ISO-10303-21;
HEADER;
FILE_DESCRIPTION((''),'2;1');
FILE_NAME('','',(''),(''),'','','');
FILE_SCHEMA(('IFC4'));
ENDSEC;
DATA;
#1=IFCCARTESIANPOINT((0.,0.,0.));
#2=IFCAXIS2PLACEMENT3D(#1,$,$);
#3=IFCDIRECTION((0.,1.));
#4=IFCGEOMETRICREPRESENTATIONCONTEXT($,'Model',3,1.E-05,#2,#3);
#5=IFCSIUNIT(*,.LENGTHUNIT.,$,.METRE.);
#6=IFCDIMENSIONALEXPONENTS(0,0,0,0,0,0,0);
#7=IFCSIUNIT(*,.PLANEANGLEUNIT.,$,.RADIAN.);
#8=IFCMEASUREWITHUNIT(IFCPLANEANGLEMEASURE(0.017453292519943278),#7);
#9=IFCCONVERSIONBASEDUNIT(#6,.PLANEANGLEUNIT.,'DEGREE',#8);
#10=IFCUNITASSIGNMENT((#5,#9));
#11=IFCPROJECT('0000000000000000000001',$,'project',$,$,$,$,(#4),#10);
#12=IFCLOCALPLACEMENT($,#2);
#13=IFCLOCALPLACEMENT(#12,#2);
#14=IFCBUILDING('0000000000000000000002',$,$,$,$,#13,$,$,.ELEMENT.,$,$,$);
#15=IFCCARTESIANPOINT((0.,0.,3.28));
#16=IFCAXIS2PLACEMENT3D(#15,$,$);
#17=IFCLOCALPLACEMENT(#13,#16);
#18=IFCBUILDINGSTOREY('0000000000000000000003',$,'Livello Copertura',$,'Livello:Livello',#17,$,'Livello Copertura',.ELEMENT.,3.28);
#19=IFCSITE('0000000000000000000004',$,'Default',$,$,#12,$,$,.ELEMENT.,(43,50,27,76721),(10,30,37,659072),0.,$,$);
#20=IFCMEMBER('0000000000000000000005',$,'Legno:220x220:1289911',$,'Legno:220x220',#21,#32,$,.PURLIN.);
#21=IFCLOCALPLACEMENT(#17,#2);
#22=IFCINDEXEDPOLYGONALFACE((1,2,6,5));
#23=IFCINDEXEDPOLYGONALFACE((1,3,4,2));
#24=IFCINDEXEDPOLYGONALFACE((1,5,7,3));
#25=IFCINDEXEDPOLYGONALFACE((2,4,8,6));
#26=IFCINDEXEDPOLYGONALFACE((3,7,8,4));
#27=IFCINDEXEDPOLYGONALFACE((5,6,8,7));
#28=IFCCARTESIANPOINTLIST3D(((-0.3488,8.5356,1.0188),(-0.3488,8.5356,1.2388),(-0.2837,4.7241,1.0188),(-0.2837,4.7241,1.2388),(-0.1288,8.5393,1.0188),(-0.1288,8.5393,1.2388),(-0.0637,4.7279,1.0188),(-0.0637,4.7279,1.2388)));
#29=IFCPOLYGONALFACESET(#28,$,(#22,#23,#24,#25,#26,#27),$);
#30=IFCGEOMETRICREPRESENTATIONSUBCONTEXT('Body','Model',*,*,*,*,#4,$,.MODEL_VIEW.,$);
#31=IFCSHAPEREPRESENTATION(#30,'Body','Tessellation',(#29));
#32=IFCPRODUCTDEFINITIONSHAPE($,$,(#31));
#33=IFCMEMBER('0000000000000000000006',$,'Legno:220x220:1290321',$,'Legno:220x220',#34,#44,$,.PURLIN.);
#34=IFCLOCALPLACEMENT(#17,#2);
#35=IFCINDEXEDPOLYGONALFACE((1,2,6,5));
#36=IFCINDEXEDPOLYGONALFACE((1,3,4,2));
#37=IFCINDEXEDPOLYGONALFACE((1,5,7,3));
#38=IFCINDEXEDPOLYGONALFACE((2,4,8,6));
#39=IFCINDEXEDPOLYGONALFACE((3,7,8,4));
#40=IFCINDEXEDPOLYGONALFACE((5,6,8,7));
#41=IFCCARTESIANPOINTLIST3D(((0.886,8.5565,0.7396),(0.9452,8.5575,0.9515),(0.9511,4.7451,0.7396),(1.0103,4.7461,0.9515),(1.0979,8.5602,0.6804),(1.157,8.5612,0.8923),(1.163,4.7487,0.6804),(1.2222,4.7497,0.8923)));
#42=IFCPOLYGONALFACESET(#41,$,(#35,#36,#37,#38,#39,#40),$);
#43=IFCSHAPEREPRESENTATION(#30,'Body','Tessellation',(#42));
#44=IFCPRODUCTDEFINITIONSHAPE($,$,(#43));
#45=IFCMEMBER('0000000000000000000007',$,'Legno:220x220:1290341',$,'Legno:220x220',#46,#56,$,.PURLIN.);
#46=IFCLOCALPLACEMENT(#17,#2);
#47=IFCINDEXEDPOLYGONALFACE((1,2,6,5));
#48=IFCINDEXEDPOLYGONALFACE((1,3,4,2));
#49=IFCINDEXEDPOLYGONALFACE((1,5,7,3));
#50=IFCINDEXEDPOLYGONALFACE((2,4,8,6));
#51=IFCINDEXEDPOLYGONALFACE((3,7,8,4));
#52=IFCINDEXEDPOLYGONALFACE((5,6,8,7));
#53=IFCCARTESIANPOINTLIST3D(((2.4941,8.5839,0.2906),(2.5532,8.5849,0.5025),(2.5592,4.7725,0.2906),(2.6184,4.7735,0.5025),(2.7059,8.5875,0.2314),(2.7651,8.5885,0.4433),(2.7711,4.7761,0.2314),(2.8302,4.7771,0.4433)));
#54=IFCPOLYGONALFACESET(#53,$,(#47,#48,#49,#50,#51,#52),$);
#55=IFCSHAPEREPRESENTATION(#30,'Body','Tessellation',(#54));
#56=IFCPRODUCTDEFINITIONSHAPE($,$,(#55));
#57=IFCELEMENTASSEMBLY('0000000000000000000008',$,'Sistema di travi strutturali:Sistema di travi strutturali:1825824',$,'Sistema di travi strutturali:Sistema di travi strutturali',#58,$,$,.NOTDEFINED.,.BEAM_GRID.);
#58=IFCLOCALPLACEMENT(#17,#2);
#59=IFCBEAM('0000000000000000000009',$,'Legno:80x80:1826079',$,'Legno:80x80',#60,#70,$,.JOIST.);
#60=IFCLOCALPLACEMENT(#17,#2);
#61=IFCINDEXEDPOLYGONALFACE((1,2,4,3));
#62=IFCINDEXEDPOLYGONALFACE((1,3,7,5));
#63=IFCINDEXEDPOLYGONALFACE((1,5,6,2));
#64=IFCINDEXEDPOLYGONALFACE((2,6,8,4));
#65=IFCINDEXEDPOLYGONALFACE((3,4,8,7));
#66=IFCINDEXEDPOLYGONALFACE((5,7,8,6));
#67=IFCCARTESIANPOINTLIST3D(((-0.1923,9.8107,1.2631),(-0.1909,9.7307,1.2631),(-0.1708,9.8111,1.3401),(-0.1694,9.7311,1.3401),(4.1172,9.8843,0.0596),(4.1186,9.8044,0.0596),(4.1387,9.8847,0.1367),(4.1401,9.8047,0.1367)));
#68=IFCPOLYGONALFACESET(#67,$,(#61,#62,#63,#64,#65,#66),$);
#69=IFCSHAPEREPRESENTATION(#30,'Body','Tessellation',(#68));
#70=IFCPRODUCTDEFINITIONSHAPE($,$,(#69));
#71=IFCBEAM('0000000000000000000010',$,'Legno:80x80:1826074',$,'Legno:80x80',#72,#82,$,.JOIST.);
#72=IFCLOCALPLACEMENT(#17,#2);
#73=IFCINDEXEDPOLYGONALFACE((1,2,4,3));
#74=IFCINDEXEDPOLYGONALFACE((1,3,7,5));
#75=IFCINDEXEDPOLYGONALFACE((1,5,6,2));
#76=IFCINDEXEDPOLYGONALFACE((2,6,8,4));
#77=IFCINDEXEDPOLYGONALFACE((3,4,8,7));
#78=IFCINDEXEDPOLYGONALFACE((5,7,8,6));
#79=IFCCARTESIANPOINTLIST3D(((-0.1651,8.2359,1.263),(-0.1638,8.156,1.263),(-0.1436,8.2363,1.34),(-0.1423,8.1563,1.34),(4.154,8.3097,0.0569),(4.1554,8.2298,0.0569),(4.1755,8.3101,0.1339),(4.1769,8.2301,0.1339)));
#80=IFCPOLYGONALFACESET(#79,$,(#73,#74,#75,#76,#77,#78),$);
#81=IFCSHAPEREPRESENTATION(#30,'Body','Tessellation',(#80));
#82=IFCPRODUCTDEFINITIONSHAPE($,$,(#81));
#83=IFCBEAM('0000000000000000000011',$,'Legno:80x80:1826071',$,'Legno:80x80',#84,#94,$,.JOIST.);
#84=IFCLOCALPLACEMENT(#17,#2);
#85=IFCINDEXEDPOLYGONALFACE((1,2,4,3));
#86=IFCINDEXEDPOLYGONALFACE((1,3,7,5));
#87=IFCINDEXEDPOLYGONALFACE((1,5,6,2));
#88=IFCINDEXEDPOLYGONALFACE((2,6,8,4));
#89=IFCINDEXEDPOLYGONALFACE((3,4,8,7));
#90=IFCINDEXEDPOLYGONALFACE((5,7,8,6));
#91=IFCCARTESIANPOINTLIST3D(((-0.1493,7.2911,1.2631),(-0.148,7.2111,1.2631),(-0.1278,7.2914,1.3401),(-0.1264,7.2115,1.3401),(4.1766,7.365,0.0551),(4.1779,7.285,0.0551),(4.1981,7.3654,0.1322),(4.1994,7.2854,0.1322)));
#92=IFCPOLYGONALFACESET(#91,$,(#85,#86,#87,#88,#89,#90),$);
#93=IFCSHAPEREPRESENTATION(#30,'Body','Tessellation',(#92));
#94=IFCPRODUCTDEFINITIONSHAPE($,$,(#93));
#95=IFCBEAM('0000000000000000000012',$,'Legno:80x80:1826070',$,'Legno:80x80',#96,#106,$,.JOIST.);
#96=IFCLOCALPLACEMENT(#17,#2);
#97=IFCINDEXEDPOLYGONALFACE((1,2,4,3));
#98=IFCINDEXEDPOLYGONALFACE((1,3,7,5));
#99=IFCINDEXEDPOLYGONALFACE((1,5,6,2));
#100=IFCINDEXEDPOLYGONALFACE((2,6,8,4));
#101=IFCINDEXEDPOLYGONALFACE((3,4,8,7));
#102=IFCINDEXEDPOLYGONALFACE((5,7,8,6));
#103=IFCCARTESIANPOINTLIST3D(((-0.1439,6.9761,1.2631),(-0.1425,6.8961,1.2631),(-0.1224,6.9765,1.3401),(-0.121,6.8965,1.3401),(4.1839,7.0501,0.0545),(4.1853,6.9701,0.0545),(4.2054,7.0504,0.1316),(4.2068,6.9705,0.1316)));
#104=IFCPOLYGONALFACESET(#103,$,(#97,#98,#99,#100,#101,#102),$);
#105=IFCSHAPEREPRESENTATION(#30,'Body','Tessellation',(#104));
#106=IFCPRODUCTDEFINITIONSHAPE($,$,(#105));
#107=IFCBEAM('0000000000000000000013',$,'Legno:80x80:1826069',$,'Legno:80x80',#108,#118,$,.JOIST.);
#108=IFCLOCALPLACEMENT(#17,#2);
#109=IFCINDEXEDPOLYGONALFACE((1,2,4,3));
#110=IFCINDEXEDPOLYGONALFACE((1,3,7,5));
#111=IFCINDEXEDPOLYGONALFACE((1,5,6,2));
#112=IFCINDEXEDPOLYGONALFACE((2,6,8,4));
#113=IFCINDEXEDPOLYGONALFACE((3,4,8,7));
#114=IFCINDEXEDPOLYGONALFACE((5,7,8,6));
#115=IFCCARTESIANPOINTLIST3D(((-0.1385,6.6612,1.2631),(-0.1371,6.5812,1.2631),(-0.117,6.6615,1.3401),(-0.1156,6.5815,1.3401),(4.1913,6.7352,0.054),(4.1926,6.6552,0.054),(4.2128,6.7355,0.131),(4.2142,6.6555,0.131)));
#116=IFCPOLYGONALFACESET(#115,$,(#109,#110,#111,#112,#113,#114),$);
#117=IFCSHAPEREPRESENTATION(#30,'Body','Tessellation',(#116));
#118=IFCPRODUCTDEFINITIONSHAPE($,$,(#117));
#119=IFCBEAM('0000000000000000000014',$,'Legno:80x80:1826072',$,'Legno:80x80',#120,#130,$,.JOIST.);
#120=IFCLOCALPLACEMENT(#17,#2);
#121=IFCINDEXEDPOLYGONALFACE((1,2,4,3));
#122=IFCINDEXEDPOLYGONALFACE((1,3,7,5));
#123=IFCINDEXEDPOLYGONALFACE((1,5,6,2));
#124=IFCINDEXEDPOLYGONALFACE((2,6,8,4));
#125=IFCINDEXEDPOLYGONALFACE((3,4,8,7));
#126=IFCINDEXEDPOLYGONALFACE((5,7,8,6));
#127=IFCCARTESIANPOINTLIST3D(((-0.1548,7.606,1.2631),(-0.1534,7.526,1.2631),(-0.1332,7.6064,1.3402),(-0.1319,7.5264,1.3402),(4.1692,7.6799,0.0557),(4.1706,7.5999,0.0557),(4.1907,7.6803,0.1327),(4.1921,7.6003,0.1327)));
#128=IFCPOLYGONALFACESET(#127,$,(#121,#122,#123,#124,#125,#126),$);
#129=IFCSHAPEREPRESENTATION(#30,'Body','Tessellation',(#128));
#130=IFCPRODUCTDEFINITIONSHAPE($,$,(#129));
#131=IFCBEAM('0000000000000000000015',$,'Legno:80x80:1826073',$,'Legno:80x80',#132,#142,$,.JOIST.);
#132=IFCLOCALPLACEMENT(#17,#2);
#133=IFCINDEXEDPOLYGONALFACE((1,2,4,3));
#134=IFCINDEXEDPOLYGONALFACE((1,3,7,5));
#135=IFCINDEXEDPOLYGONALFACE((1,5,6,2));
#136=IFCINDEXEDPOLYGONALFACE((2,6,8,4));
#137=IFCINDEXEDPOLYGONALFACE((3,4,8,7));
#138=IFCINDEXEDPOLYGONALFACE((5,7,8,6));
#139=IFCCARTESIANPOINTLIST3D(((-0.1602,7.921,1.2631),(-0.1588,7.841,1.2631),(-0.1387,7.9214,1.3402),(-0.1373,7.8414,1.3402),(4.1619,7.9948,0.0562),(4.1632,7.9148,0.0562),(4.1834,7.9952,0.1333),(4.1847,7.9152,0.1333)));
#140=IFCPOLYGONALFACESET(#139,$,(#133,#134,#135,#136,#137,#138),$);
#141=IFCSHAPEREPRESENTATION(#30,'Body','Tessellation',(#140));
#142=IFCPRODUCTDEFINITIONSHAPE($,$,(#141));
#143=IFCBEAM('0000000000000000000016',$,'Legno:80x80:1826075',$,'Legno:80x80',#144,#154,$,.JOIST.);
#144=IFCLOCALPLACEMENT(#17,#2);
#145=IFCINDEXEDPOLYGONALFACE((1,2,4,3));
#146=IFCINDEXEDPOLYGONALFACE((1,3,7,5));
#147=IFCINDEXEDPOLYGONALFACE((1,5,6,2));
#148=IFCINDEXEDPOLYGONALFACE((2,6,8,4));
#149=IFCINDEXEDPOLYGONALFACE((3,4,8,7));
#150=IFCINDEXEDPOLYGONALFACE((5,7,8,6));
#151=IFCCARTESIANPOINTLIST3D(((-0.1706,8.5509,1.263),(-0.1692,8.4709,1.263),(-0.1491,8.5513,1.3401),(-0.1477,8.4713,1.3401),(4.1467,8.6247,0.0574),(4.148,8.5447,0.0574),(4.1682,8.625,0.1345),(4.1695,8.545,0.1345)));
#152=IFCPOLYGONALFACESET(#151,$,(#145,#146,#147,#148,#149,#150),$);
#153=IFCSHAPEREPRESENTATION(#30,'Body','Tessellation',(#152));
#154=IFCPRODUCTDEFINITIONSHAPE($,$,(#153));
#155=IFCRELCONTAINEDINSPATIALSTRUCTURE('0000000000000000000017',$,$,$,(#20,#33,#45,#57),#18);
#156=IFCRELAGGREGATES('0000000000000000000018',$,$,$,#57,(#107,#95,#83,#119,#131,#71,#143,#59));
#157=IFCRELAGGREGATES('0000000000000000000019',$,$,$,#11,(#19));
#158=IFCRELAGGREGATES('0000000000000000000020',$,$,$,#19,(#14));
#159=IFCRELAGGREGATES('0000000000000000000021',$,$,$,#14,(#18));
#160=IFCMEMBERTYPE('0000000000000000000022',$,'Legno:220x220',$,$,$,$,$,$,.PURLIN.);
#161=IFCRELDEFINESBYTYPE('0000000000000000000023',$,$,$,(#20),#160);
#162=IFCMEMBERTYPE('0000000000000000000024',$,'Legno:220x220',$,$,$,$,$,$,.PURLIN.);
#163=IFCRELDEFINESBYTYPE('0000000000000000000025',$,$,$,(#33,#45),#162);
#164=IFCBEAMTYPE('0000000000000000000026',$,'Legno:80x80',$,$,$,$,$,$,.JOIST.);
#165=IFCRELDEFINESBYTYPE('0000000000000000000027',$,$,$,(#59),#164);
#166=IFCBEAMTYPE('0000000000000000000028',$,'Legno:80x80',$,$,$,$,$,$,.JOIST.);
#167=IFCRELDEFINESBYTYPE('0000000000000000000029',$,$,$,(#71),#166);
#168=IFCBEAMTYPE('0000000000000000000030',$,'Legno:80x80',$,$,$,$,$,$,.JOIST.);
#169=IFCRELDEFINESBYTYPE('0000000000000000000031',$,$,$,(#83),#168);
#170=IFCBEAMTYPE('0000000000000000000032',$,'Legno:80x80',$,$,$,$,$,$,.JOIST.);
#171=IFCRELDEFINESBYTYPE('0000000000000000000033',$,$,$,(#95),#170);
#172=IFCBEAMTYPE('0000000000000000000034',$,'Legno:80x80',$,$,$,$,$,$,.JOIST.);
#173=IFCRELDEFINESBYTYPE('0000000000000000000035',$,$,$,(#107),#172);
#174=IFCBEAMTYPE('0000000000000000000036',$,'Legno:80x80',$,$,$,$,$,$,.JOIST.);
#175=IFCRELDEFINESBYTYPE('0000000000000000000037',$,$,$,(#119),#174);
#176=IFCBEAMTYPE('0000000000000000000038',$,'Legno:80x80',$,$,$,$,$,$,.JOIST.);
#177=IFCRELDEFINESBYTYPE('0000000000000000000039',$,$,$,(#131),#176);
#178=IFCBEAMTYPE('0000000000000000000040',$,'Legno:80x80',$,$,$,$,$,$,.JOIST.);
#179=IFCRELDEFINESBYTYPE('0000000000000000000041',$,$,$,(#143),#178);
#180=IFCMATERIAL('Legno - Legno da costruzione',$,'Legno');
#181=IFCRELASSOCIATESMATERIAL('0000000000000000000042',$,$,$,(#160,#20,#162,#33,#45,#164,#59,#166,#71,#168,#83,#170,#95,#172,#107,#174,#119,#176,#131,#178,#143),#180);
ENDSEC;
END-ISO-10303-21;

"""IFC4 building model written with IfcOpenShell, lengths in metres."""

from ifc_helpers import new_model, entity, si_unit, converted_unit, direction, frame, origin, place, context, subcontext, project, spatial, indexed_curve, outline, extrude, source, transform, mapped, material, type_object, type_shapes, element, aggregate, save


model = new_model("IFC4")

# Units and contexts
model_context = context("Model", 3, precision=1e-05, world=origin(), true_north=direction((0.0, 1.0)))
body_context = subcontext(model_context, "Body", "Model", "MODEL_VIEW")
ifc_project = project(units=[si_unit("LENGTHUNIT", "METRE"), converted_unit("PLANEANGLEUNIT", "DEGREE", entity("IfcPlaneAngleMeasure", 0.017453292519943278), si_unit("PLANEANGLEUNIT", "RADIAN"), dimensions=[0, 0, 0, 0, 0, 0, 0])], contexts=[model_context])

# Site, building, storey
site_placement = place(None, origin())
site = spatial("IfcSite", under=ifc_project, at=site_placement, Name="Default", CompositionType="ELEMENT", RefLatitude=(43, 50, 27, 76721), RefLongitude=(10, 30, 37, 659072), RefElevation=0.0)
building_placement = place(site_placement, origin())
building = spatial("IfcBuilding", under=site, at=building_placement, CompositionType="ELEMENT")
storey_placement = place(building_placement, frame((0.0, 0.0, 3.28)))
storey = spatial("IfcBuildingStorey", under=building, at=storey_placement, Name="Livello Copertura", ObjectType="Livello:Livello", LongName="Livello Copertura", CompositionType="ELEMENT", Elevation=3.28)

# Members
ifc_material_1 = material(Name="Legno - Legno da costruzione", Category="Legno")
member_type_1 = type_object("IfcMemberType", Name="Legno:220x220", PredefinedType="PURLIN", material=ifc_material_1)
shared_shape_1 = source(origin(), body_context, "Body", "SweptSolid", [
    extrude(outline(indexed_curve([(-1.906, -0.11), (1.906, -0.11), (1.906, 0.11), (-1.906, 0.11), (-1.906, -0.11)], self_intersect=False)), frame((0.0, 0.0, -0.11), z_axis=(0.0, 0.0, 1.0), x_axis=(-1.0, 0.0, 0.0)), (0.0, 0.0, 1.0), 0.22),
])
type_shapes(member_type_1, [shared_shape_1])
member_placement = place(storey_placement, frame((-0.2063, 6.6317, 1.1288), z_axis=(0.0, 0.0, 1.0), x_axis=(0.017085, -0.999854, 0.0)))
element("IfcMember", 1, at=member_placement, inside=storey, type_object=member_type_1, material=ifc_material_1, Name="Legno:220x220:1289911", ObjectType="Legno:220x220", PredefinedType="PURLIN", context=body_context, shape_type="MappedRepresentation", body=[
    mapped(shared_shape_1, transform((0.0, 0.0, 0.0), scale=1.0)),
])
member_type_2 = type_object("IfcMemberType", Name="Legno:220x220", PredefinedType="PURLIN", material=ifc_material_1)
shared_shape_2 = source(origin(), body_context, "Body", "SweptSolid", [
    extrude(outline(indexed_curve([(-1.906, -0.11), (1.906, -0.11), (1.906, 0.11), (-1.906, 0.11), (-1.906, -0.11)], self_intersect=False)), frame((0.0, 0.0, -0.11), z_axis=(0.0, 0.0, 1.0), x_axis=(-1.0, 0.0, 0.0)), (0.0, 0.0, 1.0), 0.22),
])
type_shapes(member_type_2, [shared_shape_2])
for number, where, z_axis, x_axis, name in (
    (2, (1.0541, 6.6531, 0.816), (0.268881, 0.004594, 0.963163), (0.017085, -0.999854, 0.0), "Legno:220x220:1290321"),
    (3, (2.6622, 6.6805, 0.3669), (0.268881, 0.004594, 0.963163), (0.017085, -0.999854, 0.0), "Legno:220x220:1290341"),
):
    element("IfcMember", number, at=place(storey_placement, frame(where, z_axis=z_axis, x_axis=x_axis)), inside=storey, type_object=member_type_2, material=ifc_material_1, Name=name, ObjectType="Legno:220x220", PredefinedType="PURLIN", context=body_context, shape_type="MappedRepresentation", body=[
        mapped(shared_shape_2, transform((0.0, 0.0, 0.0), scale=1.0)),
    ])

# Element assembly, beams
assembly_1_placement = place(storey_placement, origin())
assembly_1 = element("IfcElementAssembly", 4, at=assembly_1_placement, inside=storey, Name="Sistema di travi strutturali:Sistema di travi strutturali:1825824", ObjectType="Sistema di travi strutturali:Sistema di travi strutturali", AssemblyPlace="NOTDEFINED", PredefinedType="BEAM_GRID")
beam_type_1 = type_object("IfcBeamType", Name="Legno:80x80", PredefinedType="JOIST", material=ifc_material_1)
shared_shape_3 = source(origin(), body_context, "Body", "SweptSolid", [
    extrude(outline(indexed_curve([(-2.2375, -0.04), (2.2375, -0.04), (2.2375, 0.04), (-2.2375, 0.04), (-2.2375, -0.04)], self_intersect=False)), frame((0.0, 0.0, -0.04), z_axis=(0.0, 0.0, 1.0), x_axis=(-1.0, 0.0, 0.0)), (0.0, 0.0, 1.0), 0.08),
])
type_shapes(beam_type_1, [shared_shape_3])
beam_1_placement = place(assembly_1_placement, frame((1.9739, 9.8077, 0.6999), z_axis=(0.268881, 0.004594, 0.963163), x_axis=(-0.963022, -0.016456, 0.26892)))
beam_1 = element("IfcBeam", 5, at=beam_1_placement, type_object=beam_type_1, material=ifc_material_1, Name="Legno:80x80:1826079", ObjectType="Legno:80x80", PredefinedType="JOIST", context=body_context, shape_type="MappedRepresentation", body=[
    mapped(shared_shape_3, transform((0.0, 0.0, 0.0), scale=1.0)),
])
beam_type_2 = type_object("IfcBeamType", Name="Legno:80x80", PredefinedType="JOIST", material=ifc_material_1)
shared_shape_4 = source(origin(), body_context, "Body", "SweptSolid", [
    extrude(outline(indexed_curve([(-2.2425, -0.04), (2.2425, -0.04), (2.2425, 0.04), (-2.2425, 0.04), (-2.2425, -0.04)], self_intersect=False)), frame((0.0, 0.0, -0.04), z_axis=(0.0, 0.0, 1.0), x_axis=(-1.0, 0.0, 0.0)), (0.0, 0.0, 1.0), 0.08),
])
type_shapes(beam_type_2, [shared_shape_4])
beam_2_placement = place(assembly_1_placement, frame((2.0059, 8.233, 0.6985), z_axis=(0.268881, 0.004594, 0.963163), x_axis=(-0.963022, -0.016456, 0.26892)))
beam_2 = element("IfcBeam", 6, at=beam_2_placement, type_object=beam_type_2, material=ifc_material_1, Name="Legno:80x80:1826074", ObjectType="Legno:80x80", PredefinedType="JOIST", context=body_context, shape_type="MappedRepresentation", body=[
    mapped(shared_shape_4, transform((0.0, 0.0, 0.0), scale=1.0)),
])
beam_type_3 = type_object("IfcBeamType", Name="Legno:80x80", PredefinedType="JOIST", material=ifc_material_1)
shared_shape_5 = source(origin(), body_context, "Body", "SweptSolid", [
    extrude(outline(indexed_curve([(-2.246, -0.04), (2.246, -0.04), (2.246, 0.04), (-2.246, 0.04), (-2.246, -0.04)], self_intersect=False)), frame((0.0, 0.0, -0.04), z_axis=(0.0, 0.0, 1.0), x_axis=(-1.0, 0.0, 0.0)), (0.0, 0.0, 1.0), 0.08),
])
type_shapes(beam_type_3, [shared_shape_5])
beam_3_placement = place(assembly_1_placement, frame((2.0251, 7.2882, 0.6976), z_axis=(0.268881, 0.004594, 0.963163), x_axis=(-0.963022, -0.016456, 0.26892)))
beam_3 = element("IfcBeam", 7, at=beam_3_placement, type_object=beam_type_3, material=ifc_material_1, Name="Legno:80x80:1826071", ObjectType="Legno:80x80", PredefinedType="JOIST", context=body_context, shape_type="MappedRepresentation", body=[
    mapped(shared_shape_5, transform((0.0, 0.0, 0.0), scale=1.0)),
])
beam_type_4 = type_object("IfcBeamType", Name="Legno:80x80", PredefinedType="JOIST", material=ifc_material_1)
shared_shape_6 = source(origin(), body_context, "Body", "SweptSolid", [
    extrude(outline(indexed_curve([(-2.247, -0.04), (2.247, -0.04), (2.247, 0.04), (-2.247, 0.04), (-2.247, -0.04)], self_intersect=False)), frame((0.0, 0.0, -0.04), z_axis=(0.0, 0.0, 1.0), x_axis=(-1.0, 0.0, 0.0)), (0.0, 0.0, 1.0), 0.08),
])
type_shapes(beam_type_4, [shared_shape_6])
beam_4_placement = place(assembly_1_placement, frame((2.0315, 6.9733, 0.6973), z_axis=(0.268881, 0.004594, 0.963163), x_axis=(-0.963022, -0.016456, 0.26892)))
beam_4 = element("IfcBeam", 8, at=beam_4_placement, type_object=beam_type_4, material=ifc_material_1, Name="Legno:80x80:1826070", ObjectType="Legno:80x80", PredefinedType="JOIST", context=body_context, shape_type="MappedRepresentation", body=[
    mapped(shared_shape_6, transform((0.0, 0.0, 0.0), scale=1.0)),
])
beam_type_5 = type_object("IfcBeamType", Name="Legno:80x80", PredefinedType="JOIST", material=ifc_material_1)
shared_shape_7 = source(origin(), body_context, "Body", "SweptSolid", [
    extrude(outline(indexed_curve([(-2.248, -0.04), (2.248, -0.04), (2.248, 0.04), (-2.248, 0.04), (-2.248, -0.04)], self_intersect=False)), frame((0.0, 0.0, -0.04), z_axis=(0.0, 0.0, 1.0), x_axis=(-1.0, 0.0, 0.0)), (0.0, 0.0, 1.0), 0.08),
])
type_shapes(beam_type_5, [shared_shape_7])
beam_5_placement = place(assembly_1_placement, frame((2.0378, 6.6584, 0.6971), z_axis=(0.268881, 0.004594, 0.963163), x_axis=(-0.963022, -0.016456, 0.26892)))
beam_5 = element("IfcBeam", 9, at=beam_5_placement, type_object=beam_type_5, material=ifc_material_1, Name="Legno:80x80:1826069", ObjectType="Legno:80x80", PredefinedType="JOIST", context=body_context, shape_type="MappedRepresentation", body=[
    mapped(shared_shape_7, transform((0.0, 0.0, 0.0), scale=1.0)),
])
beam_type_6 = type_object("IfcBeamType", Name="Legno:80x80", PredefinedType="JOIST", material=ifc_material_1)
shared_shape_8 = source(origin(), body_context, "Body", "SweptSolid", [
    extrude(outline(indexed_curve([(-2.245, -0.04), (2.245, -0.04), (2.245, 0.04), (-2.245, 0.04), (-2.245, -0.04)], self_intersect=False)), frame((0.0, 0.0, -0.04), z_axis=(0.0, 0.0, 1.0), x_axis=(-1.0, 0.0, 0.0)), (0.0, 0.0, 1.0), 0.08),
])
type_shapes(beam_type_6, [shared_shape_8])
beam_6_placement = place(assembly_1_placement, frame((2.0187, 7.6032, 0.6979), z_axis=(0.268881, 0.004594, 0.963163), x_axis=(-0.963022, -0.016456, 0.26892)))
beam_6 = element("IfcBeam", 10, at=beam_6_placement, type_object=beam_type_6, material=ifc_material_1, Name="Legno:80x80:1826072", ObjectType="Legno:80x80", PredefinedType="JOIST", context=body_context, shape_type="MappedRepresentation", body=[
    mapped(shared_shape_8, transform((0.0, 0.0, 0.0), scale=1.0)),
])
beam_type_7 = type_object("IfcBeamType", Name="Legno:80x80", PredefinedType="JOIST", material=ifc_material_1)
shared_shape_9 = source(origin(), body_context, "Body", "SweptSolid", [
    extrude(outline(indexed_curve([(-2.244, -0.04), (2.244, -0.04), (2.244, 0.04), (-2.244, 0.04), (-2.244, -0.04)], self_intersect=False)), frame((0.0, 0.0, -0.04), z_axis=(0.0, 0.0, 1.0), x_axis=(-1.0, 0.0, 0.0)), (0.0, 0.0, 1.0), 0.08),
])
type_shapes(beam_type_7, [shared_shape_9])
beam_7_placement = place(assembly_1_placement, frame((2.0123, 7.9181, 0.6982), z_axis=(0.268881, 0.004594, 0.963163), x_axis=(-0.963022, -0.016456, 0.26892)))
beam_7 = element("IfcBeam", 11, at=beam_7_placement, type_object=beam_type_7, material=ifc_material_1, Name="Legno:80x80:1826073", ObjectType="Legno:80x80", PredefinedType="JOIST", context=body_context, shape_type="MappedRepresentation", body=[
    mapped(shared_shape_9, transform((0.0, 0.0, 0.0), scale=1.0)),
])
beam_type_8 = type_object("IfcBeamType", Name="Legno:80x80", PredefinedType="JOIST", material=ifc_material_1)
shared_shape_10 = source(origin(), body_context, "Body", "SweptSolid", [
    extrude(outline(indexed_curve([(-2.2415, -0.04), (2.2415, -0.04), (2.2415, 0.04), (-2.2415, 0.04), (-2.2415, -0.04)], self_intersect=False)), frame((0.0, 0.0, -0.04), z_axis=(0.0, 0.0, 1.0), x_axis=(-1.0, 0.0, 0.0)), (0.0, 0.0, 1.0), 0.08),
])
type_shapes(beam_type_8, [shared_shape_10])
beam_8_placement = place(assembly_1_placement, frame((1.9995, 8.548, 0.6987), z_axis=(0.268881, 0.004594, 0.963163), x_axis=(-0.963022, -0.016456, 0.26892)))
beam_8 = element("IfcBeam", 12, at=beam_8_placement, type_object=beam_type_8, material=ifc_material_1, Name="Legno:80x80:1826075", ObjectType="Legno:80x80", PredefinedType="JOIST", context=body_context, shape_type="MappedRepresentation", body=[
    mapped(shared_shape_10, transform((0.0, 0.0, 0.0), scale=1.0)),
])
aggregate(assembly_1, [beam_5, beam_4, beam_3, beam_6, beam_7, beam_2, beam_8, beam_1])

save(model, "model.ifc")
